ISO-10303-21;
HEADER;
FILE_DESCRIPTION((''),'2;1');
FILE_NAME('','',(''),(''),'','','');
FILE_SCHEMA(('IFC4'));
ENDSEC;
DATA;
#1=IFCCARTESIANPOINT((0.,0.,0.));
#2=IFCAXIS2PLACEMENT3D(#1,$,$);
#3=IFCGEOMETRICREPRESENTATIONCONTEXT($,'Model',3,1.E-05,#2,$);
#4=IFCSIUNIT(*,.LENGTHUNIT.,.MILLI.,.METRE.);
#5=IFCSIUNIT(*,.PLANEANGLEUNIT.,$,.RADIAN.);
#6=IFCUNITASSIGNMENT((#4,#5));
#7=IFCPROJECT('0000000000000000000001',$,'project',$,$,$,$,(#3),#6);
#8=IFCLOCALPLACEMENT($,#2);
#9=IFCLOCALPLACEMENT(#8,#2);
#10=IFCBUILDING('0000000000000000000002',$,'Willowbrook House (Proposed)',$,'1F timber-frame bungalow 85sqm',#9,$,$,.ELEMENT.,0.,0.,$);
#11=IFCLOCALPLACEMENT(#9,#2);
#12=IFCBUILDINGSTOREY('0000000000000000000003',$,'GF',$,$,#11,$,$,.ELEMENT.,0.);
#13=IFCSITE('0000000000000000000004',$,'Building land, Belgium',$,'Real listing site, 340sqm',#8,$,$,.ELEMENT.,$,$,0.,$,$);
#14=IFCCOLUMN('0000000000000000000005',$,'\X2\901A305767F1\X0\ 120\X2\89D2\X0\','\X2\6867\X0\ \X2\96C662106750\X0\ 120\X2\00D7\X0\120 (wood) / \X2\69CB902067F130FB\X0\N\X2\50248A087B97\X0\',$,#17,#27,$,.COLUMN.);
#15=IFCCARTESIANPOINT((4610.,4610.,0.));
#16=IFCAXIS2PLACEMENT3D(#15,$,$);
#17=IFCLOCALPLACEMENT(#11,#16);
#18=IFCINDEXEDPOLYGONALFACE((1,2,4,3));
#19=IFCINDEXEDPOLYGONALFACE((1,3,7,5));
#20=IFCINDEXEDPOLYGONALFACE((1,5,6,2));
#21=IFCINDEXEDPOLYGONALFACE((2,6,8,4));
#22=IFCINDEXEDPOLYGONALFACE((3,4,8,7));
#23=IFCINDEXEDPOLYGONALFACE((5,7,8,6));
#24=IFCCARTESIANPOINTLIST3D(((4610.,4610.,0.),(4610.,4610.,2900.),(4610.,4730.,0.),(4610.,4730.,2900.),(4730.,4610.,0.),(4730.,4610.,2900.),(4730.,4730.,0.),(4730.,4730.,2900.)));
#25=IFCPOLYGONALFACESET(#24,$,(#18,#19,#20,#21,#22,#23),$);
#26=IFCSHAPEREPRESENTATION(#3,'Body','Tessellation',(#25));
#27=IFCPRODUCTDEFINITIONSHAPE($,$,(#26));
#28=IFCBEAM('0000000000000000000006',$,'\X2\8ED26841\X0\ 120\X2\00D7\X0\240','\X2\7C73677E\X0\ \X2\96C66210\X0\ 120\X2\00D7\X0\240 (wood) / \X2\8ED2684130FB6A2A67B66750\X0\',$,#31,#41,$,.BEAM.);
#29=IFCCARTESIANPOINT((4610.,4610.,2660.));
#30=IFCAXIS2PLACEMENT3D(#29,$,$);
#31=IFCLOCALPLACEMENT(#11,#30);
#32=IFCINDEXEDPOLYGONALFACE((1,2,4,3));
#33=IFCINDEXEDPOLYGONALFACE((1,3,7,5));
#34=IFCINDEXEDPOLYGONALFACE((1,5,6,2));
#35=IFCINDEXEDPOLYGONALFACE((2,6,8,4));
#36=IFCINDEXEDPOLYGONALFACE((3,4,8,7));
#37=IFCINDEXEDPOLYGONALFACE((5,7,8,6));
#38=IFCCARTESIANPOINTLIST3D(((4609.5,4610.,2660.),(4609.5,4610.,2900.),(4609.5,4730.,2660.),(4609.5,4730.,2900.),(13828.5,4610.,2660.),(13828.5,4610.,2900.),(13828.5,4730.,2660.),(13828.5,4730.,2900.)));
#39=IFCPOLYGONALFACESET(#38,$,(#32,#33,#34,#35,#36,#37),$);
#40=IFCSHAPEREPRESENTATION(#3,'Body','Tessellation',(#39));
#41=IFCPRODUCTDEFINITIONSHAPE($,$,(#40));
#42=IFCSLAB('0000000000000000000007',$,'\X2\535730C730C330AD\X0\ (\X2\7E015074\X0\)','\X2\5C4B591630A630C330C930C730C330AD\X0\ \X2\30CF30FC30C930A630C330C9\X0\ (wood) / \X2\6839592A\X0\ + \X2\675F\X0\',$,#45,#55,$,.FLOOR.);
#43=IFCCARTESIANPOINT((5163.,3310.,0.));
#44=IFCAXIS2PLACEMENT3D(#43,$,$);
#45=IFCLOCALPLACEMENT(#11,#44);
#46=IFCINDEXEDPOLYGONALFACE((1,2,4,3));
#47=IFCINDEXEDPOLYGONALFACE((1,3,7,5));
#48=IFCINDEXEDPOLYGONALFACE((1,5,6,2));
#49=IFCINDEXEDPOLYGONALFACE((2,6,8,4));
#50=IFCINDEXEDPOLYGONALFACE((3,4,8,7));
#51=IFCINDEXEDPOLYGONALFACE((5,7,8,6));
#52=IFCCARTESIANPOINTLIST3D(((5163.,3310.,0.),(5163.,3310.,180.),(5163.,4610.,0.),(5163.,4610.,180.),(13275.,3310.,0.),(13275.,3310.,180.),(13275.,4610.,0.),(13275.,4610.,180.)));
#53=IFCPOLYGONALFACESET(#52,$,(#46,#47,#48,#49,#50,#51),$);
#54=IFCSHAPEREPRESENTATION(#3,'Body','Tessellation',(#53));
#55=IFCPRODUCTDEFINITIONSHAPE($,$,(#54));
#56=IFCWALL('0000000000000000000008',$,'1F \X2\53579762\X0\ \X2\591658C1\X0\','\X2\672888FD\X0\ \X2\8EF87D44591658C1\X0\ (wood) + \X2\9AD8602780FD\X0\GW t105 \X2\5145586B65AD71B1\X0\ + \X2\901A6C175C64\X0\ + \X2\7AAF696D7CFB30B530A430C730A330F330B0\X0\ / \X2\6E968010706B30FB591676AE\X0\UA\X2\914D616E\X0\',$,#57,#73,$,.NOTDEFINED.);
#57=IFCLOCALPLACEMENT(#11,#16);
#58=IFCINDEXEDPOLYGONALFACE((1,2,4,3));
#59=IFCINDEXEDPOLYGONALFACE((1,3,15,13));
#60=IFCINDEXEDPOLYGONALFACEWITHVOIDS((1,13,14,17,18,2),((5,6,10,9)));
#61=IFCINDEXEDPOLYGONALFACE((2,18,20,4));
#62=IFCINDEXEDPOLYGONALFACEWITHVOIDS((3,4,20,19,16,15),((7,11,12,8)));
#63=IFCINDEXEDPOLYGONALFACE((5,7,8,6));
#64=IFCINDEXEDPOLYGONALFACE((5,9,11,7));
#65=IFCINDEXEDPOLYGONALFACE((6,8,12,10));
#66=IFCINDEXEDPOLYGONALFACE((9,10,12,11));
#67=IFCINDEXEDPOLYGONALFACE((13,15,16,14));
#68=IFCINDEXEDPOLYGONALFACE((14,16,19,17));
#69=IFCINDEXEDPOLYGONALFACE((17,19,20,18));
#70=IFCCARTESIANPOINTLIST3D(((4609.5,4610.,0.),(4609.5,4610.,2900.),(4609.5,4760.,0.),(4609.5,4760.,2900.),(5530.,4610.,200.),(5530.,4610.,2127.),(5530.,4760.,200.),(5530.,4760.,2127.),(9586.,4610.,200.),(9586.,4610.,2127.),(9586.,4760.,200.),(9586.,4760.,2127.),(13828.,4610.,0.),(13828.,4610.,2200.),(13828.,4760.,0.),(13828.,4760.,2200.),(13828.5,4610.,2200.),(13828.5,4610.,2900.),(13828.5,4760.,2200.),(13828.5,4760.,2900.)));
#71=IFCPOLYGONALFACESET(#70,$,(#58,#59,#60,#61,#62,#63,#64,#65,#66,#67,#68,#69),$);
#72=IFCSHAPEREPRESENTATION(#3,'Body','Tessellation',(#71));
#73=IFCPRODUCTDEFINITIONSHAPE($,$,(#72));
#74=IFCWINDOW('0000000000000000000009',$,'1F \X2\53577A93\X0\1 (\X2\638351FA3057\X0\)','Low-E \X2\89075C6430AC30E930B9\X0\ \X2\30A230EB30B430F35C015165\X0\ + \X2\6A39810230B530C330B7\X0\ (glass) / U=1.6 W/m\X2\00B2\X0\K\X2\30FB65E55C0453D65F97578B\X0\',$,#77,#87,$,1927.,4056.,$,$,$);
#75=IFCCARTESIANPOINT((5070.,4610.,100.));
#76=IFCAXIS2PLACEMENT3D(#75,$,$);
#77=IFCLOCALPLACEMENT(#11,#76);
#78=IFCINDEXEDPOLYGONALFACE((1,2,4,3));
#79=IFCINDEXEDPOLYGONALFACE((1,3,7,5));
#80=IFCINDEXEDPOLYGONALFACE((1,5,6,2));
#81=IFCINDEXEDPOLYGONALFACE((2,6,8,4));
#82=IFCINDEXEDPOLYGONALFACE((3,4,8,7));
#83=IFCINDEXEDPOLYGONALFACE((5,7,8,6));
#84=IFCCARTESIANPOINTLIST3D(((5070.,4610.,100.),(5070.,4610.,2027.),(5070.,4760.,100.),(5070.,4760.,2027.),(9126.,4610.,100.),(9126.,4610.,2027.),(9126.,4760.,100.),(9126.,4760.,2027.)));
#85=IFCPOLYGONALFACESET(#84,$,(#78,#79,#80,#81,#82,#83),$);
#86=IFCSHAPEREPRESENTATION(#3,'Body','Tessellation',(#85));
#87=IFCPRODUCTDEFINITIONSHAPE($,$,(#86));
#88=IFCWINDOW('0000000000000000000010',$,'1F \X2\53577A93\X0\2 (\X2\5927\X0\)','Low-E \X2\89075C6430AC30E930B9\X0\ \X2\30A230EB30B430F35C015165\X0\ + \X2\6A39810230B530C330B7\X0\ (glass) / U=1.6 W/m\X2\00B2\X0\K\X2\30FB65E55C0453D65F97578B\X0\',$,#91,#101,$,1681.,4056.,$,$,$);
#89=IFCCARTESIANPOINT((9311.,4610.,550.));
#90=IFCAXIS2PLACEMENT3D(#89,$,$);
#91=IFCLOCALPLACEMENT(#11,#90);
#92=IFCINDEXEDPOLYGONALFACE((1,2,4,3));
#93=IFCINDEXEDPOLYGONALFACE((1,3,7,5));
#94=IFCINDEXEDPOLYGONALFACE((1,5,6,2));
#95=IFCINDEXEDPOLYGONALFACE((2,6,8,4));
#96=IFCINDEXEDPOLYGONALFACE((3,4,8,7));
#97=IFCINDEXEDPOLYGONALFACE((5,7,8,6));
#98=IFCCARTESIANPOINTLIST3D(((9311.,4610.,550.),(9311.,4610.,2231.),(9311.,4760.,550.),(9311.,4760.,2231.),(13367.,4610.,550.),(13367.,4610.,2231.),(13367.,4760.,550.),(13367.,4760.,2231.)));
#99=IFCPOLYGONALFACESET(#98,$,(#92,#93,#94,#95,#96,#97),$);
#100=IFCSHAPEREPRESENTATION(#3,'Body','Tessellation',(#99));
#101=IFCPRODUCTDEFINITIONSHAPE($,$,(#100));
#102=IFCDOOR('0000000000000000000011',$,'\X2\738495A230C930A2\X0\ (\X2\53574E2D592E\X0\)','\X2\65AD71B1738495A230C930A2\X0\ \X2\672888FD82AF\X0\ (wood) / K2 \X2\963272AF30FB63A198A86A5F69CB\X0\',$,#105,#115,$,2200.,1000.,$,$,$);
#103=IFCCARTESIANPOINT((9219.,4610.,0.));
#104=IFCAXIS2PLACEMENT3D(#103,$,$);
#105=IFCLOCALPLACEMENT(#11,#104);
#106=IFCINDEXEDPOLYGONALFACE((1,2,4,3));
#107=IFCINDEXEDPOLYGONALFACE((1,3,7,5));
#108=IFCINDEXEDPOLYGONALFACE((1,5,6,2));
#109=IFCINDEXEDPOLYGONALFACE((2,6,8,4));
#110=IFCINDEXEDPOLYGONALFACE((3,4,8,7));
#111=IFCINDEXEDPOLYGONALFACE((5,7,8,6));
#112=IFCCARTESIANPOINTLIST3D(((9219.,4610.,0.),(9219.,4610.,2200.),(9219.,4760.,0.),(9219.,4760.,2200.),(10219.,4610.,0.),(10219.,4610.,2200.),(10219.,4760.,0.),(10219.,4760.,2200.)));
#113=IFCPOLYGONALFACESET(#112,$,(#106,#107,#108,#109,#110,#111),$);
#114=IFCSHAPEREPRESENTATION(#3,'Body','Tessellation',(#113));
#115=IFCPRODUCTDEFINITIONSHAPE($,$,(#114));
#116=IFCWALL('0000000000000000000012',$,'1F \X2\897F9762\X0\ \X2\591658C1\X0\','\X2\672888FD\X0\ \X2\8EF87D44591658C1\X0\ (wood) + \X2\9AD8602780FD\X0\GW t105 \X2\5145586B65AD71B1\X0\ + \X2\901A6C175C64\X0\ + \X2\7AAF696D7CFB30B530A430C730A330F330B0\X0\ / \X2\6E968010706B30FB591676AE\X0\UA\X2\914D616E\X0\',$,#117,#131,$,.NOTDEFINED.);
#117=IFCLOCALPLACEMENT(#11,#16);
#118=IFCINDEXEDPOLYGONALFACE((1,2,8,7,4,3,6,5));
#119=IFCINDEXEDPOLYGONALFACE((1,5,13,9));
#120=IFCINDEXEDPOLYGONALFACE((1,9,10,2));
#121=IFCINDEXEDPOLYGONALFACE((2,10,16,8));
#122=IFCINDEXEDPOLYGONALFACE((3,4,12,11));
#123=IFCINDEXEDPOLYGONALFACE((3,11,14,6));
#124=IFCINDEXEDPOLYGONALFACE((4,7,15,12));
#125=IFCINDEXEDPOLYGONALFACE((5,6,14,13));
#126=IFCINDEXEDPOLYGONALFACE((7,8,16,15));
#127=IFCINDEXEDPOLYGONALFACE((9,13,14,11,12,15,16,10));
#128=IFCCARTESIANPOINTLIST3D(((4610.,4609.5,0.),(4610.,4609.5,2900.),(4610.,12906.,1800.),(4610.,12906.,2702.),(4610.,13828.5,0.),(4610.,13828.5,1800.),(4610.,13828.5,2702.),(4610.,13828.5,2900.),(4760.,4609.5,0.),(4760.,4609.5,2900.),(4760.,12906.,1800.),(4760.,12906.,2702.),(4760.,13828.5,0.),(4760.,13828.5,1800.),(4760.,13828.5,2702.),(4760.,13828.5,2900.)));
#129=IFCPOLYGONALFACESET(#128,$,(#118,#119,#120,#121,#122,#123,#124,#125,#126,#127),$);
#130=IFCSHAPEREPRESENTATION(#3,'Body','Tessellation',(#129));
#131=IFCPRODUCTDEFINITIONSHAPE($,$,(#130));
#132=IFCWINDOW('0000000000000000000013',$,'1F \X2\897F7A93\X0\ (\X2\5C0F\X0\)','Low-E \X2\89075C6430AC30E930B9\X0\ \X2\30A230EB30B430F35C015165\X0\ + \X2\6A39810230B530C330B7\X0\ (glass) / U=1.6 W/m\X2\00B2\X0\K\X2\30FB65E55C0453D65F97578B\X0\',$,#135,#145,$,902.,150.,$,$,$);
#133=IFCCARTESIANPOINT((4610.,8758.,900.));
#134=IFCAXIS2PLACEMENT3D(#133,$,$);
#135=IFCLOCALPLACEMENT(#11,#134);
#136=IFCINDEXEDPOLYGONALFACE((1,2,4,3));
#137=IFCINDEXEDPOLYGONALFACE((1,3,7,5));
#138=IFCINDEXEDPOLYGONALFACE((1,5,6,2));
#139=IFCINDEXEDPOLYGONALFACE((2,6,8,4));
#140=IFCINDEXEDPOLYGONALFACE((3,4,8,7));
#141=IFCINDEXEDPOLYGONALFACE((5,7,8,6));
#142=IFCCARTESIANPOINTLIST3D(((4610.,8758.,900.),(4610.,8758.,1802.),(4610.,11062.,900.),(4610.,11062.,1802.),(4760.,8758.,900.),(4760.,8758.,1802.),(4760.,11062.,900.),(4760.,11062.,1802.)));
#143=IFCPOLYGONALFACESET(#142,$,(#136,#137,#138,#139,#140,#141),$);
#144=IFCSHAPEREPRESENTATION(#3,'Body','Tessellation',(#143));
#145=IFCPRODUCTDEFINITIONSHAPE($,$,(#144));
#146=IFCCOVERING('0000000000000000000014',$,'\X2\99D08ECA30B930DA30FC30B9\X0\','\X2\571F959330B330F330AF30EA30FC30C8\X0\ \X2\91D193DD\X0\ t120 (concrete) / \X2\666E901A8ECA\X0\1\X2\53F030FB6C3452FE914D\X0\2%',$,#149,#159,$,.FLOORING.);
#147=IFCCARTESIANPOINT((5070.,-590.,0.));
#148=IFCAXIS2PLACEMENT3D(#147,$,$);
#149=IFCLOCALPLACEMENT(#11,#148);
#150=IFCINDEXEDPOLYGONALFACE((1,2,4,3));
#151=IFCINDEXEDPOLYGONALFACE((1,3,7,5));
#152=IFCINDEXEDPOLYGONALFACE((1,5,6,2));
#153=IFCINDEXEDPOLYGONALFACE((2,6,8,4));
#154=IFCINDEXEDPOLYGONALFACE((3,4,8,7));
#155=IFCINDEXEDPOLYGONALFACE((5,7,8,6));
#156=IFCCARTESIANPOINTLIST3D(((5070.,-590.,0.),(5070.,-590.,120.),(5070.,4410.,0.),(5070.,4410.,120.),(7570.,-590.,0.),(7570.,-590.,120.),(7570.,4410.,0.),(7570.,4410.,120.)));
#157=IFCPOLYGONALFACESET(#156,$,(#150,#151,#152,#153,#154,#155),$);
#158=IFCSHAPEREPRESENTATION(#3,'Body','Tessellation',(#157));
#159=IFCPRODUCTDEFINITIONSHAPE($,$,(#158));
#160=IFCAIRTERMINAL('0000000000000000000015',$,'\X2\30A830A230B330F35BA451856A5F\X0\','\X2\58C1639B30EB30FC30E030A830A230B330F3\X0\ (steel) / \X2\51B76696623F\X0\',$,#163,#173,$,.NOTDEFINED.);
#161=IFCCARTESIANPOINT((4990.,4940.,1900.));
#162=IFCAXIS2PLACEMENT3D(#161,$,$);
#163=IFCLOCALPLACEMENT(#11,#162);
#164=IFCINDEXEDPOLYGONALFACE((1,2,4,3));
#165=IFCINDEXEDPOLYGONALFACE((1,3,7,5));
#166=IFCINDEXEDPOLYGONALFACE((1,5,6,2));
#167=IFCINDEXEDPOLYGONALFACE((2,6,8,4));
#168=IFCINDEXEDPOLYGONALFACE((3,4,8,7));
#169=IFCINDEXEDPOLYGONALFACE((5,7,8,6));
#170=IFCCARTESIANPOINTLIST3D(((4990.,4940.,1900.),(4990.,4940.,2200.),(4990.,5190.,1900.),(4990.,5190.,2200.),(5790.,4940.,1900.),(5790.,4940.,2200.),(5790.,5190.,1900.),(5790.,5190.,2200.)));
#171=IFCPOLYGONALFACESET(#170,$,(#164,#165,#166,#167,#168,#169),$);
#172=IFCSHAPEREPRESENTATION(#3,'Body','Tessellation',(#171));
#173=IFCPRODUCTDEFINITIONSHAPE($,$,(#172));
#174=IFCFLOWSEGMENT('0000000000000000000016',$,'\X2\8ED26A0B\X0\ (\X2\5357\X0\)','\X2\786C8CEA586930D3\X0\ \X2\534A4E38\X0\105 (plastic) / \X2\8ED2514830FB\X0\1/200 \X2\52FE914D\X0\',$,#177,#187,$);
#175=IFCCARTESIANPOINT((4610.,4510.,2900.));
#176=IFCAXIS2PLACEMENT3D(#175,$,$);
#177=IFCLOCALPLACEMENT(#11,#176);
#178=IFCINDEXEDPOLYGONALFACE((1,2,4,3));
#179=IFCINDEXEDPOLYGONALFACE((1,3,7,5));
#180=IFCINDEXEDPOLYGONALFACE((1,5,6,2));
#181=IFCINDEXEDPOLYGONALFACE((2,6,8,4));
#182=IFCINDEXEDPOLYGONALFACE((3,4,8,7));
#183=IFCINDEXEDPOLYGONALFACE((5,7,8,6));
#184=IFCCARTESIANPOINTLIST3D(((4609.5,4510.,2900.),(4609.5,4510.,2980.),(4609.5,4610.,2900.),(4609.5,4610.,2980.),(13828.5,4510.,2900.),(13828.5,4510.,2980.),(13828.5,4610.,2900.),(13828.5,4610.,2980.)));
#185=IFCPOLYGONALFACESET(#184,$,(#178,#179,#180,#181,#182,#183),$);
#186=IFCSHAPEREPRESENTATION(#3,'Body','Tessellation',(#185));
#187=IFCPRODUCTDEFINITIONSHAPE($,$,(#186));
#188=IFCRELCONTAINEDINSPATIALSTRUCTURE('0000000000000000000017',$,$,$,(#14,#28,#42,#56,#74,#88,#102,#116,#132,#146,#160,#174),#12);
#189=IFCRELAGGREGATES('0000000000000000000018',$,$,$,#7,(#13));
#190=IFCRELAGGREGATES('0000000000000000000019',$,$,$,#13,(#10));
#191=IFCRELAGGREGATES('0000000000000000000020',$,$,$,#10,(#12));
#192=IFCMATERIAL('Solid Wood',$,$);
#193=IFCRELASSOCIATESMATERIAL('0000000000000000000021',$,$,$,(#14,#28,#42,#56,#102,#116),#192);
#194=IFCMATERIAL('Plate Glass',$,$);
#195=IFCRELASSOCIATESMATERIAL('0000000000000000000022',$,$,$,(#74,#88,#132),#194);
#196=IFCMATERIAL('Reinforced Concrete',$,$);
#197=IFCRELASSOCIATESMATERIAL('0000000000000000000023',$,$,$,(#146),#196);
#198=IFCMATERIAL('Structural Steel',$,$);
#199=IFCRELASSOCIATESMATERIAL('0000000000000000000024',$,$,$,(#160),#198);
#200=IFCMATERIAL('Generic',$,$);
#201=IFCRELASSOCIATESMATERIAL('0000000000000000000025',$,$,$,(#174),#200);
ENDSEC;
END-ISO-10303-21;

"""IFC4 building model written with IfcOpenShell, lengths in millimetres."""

from ifc_helpers import new_model, si_unit, frame, frame_2d, origin, place, context, project, spatial, rectangle, extrude, material, element, fill, save


model = new_model("IFC4")

# Units and contexts
model_context = context("Model", 3, precision=1e-05, world=origin())
ifc_project = project(units=[si_unit("LENGTHUNIT", "METRE", prefix="MILLI"), si_unit("PLANEANGLEUNIT", "RADIAN")], contexts=[model_context])

# Site, building, storey
site_placement = place(None, origin())
site = spatial("IfcSite", under=ifc_project, at=site_placement, Name="Building land, Belgium", ObjectType="Real listing site, 340sqm", CompositionType="ELEMENT", RefElevation=0.0)
building_placement = place(site_placement, origin())
building = spatial("IfcBuilding", under=site, at=building_placement, Name="Willowbrook House (Proposed)", ObjectType="1F timber-frame bungalow 85sqm", CompositionType="ELEMENT", ElevationOfRefHeight=0.0, ElevationOfTerrain=0.0)
storey_placement = place(building_placement, origin())
storey = spatial("IfcBuildingStorey", under=building, at=storey_placement, Name="GF", CompositionType="ELEMENT", Elevation=0.0)

# Column
ifc_material_1 = material(Name="Solid Wood")
column_1_placement = place(storey_placement, frame((4610.0, 4610.0, 0.0)))
element("IfcColumn", 1, at=column_1_placement, inside=storey, material=ifc_material_1, Name="通し柱 120角", Description="桧 集成材 120×120 (wood) / 構造柱・N値計算", PredefinedType="COLUMN", context=model_context, shape_type="SweptSolid", body=[
    extrude(rectangle(XDim=120.0, YDim=120.0, at=frame_2d((60.0, 60.0))), frame((4610.0, 4610.0, 0.0)), (0.0, 0.0, 1.0), 2900.0),
])

# Beam
beam_1_placement = place(storey_placement, frame((4610.0, 4610.0, 2660.0)))
element("IfcBeam", 2, at=beam_1_placement, inside=storey, material=ifc_material_1, Name="軒桁 120×240", Description="米松 集成 120×240 (wood) / 軒桁・横架材", PredefinedType="BEAM", context=model_context, shape_type="SweptSolid", body=[
    extrude(rectangle(XDim=9219.0, YDim=120.0, at=frame_2d((4609.0, 60.0))), frame((4610.0, 4610.0, 2660.0)), (0.0, 0.0, 1.0), 240.0),
])

# Slab
ifc_material_2 = material(Name="Reinforced Concrete")
slab_1_placement = place(storey_placement, frame((5163.0, 3310.0, 0.0)))
element("IfcSlab", 3, at=slab_1_placement, inside=storey, material=ifc_material_1, Name="南デッキ (縁側)", Description="屋外ウッドデッキ ハードウッド (wood) / 根太 + 束", PredefinedType="FLOOR", context=model_context, shape_type="SweptSolid", body=[
    extrude(rectangle(XDim=8112.0, YDim=1300.0, at=frame_2d((4056.0, 650.0))), frame((5163.0, 3310.0, 0.0)), (0.0, 0.0, 1.0), 180.0),
])

# Wall, openings, windows, door
wall_1_placement = place(storey_placement, frame((4610.0, 4610.0, 0.0)))
wall_1 = element("IfcWall", 4, at=wall_1_placement, inside=storey, material=ifc_material_1, Name="1F 南面 外壁", Description="木製 軸組外壁 (wood) + 高性能GW t105 充填断熱 + 通気層 + 窯業系サイディング / 準耐火・外皮UA配慮", PredefinedType="NOTDEFINED", context=model_context, shape_type="SweptSolid", body=[
    extrude(rectangle(XDim=9219.0, YDim=150.0, at=frame_2d((4609.0, 75.0))), frame((4610.0, 4610.0, 0.0)), (0.0, 0.0, 1.0), 2900.0),
])
opening_1_placement = place(storey_placement, frame((5070.0, 4610.0, 100.0)))
opening_1 = element("IfcOpeningElement", 5, at=opening_1_placement, cuts=wall_1, PredefinedType="NOTDEFINED", context=model_context, shape_type="SweptSolid", body=[
    extrude(rectangle(XDim=4056.0, YDim=150.0, at=frame_2d((2028.0, 75.0))), frame((5070.0, 4610.0, 100.0)), (0.0, 0.0, 1.0), 1927.0),
])
opening_2_placement = place(storey_placement, frame((9311.0, 4610.0, 550.0)))
opening_2 = element("IfcOpeningElement", 6, at=opening_2_placement, cuts=wall_1, PredefinedType="NOTDEFINED", context=model_context, shape_type="SweptSolid", body=[
    extrude(rectangle(XDim=4056.0, YDim=150.0, at=frame_2d((2028.0, 75.0))), frame((9311.0, 4610.0, 550.0)), (0.0, 0.0, 1.0), 1681.0),
])
opening_3_placement = place(storey_placement, frame((9219.0, 4610.0, 0.0)))
opening_3 = element("IfcOpeningElement", 7, at=opening_3_placement, cuts=wall_1, PredefinedType="NOTDEFINED", context=model_context, shape_type="SweptSolid", body=[
    extrude(rectangle(XDim=1000.0, YDim=150.0, at=frame_2d((500.0, 75.0))), frame((9219.0, 4610.0, 0.0)), (0.0, 0.0, 1.0), 2200.0),
])
ifc_material_3 = material(Name="Plate Glass")
window_1_placement = place(storey_placement, frame((5070.0, 4610.0, 100.0)))
window_1 = element("IfcWindow", 8, at=window_1_placement, inside=storey, material=ifc_material_3, Name="1F 南窓1 (掃出し)", Description="Low-E 複層ガラス アルゴン封入 + 樹脂サッシ (glass) / U=1.6 W/m²K・日射取得型", OverallHeight=1927.0, OverallWidth=4056.0, context=model_context, shape_type="SweptSolid", body=[
    extrude(rectangle(XDim=4056.0, YDim=150.0, at=frame_2d((2028.0, 75.0))), frame((5070.0, 4610.0, 100.0)), (0.0, 0.0, 1.0), 1927.0),
])
fill(opening_1, window_1)
window_2_placement = place(storey_placement, frame((9311.0, 4610.0, 550.0)))
window_2 = element("IfcWindow", 9, at=window_2_placement, inside=storey, material=ifc_material_3, Name="1F 南窓2 (大)", Description="Low-E 複層ガラス アルゴン封入 + 樹脂サッシ (glass) / U=1.6 W/m²K・日射取得型", OverallHeight=1681.0, OverallWidth=4056.0, context=model_context, shape_type="SweptSolid", body=[
    extrude(rectangle(XDim=4056.0, YDim=150.0, at=frame_2d((2028.0, 75.0))), frame((9311.0, 4610.0, 550.0)), (0.0, 0.0, 1.0), 1681.0),
])
fill(opening_2, window_2)
door_placement = place(storey_placement, frame((9219.0, 4610.0, 0.0)))
door = element("IfcDoor", 10, at=door_placement, inside=storey, material=ifc_material_1, Name="玄関ドア (南中央)", Description="断熱玄関ドア 木製芯 (wood) / K2 防犯・採風機構", OverallHeight=2200.0, OverallWidth=1000.0, context=model_context, shape_type="SweptSolid", body=[
    extrude(rectangle(XDim=1000.0, YDim=150.0, at=frame_2d((500.0, 75.0))), frame((9219.0, 4610.0, 0.0)), (0.0, 0.0, 1.0), 2200.0),
])
fill(opening_3, door)

# Wall, opening, window
wall_2_placement = place(storey_placement, frame((4610.0, 4610.0, 0.0)))
wall_2 = element("IfcWall", 11, at=wall_2_placement, inside=storey, material=ifc_material_1, Name="1F 西面 外壁", Description="木製 軸組外壁 (wood) + 高性能GW t105 充填断熱 + 通気層 + 窯業系サイディング / 準耐火・外皮UA配慮", PredefinedType="NOTDEFINED", context=model_context, shape_type="SweptSolid", body=[
    extrude(rectangle(XDim=150.0, YDim=9219.0, at=frame_2d((75.0, 4609.0))), frame((4610.0, 4610.0, 0.0)), (0.0, 0.0, 1.0), 2900.0),
])
opening_4_placement = place(storey_placement, frame((4610.0, 8758.0, 900.0)))
opening_4 = element("IfcOpeningElement", 12, at=opening_4_placement, cuts=wall_2, PredefinedType="NOTDEFINED", context=model_context, shape_type="SweptSolid", body=[
    extrude(rectangle(XDim=150.0, YDim=2304.0, at=frame_2d((75.0, 1152.0))), frame((4610.0, 8758.0, 900.0)), (0.0, 0.0, 1.0), 902.0),
])
window_3_placement = place(storey_placement, frame((4610.0, 8758.0, 900.0)))
window_3 = element("IfcWindow", 13, at=window_3_placement, inside=storey, material=ifc_material_3, Name="1F 西窓 (小)", Description="Low-E 複層ガラス アルゴン封入 + 樹脂サッシ (glass) / U=1.6 W/m²K・日射取得型", OverallHeight=902.0, OverallWidth=150.0, context=model_context, shape_type="SweptSolid", body=[
    extrude(rectangle(XDim=150.0, YDim=2304.0, at=frame_2d((75.0, 1152.0))), frame((4610.0, 8758.0, 900.0)), (0.0, 0.0, 1.0), 902.0),
])
fill(opening_4, window_3)

# Shared definitions
ifc_material_4 = material(Name="Structural Steel")

# Covering
ifc_material_5 = material(Name="Generic")
covering_1_placement = place(storey_placement, frame((5070.0, -590.0, 0.0)))
element("IfcCovering", 14, at=covering_1_placement, inside=storey, material=ifc_material_2, Name="駐車スペース", Description="土間コンクリート 金鏝 t120 (concrete) / 普通車1台・水勾配2%", PredefinedType="FLOORING", context=model_context, shape_type="SweptSolid", body=[
    extrude(rectangle(XDim=2500.0, YDim=5000.0, at=frame_2d((1250.0, 2500.0))), frame((5070.0, -590.0, 0.0)), (0.0, 0.0, 1.0), 120.0),
])

# Air terminal
air_terminal_placement = place(storey_placement, frame((4990.0, 4940.0, 1900.0)))
element("IfcAirTerminal", 15, at=air_terminal_placement, inside=storey, material=ifc_material_4, Name="エアコン室内機", Description="壁掛ルームエアコン (steel) / 冷暖房", PredefinedType="NOTDEFINED", context=model_context, shape_type="SweptSolid", body=[
    extrude(rectangle(XDim=800.0, YDim=250.0, at=frame_2d((400.0, 125.0))), frame((4990.0, 4940.0, 1900.0)), (0.0, 0.0, 1.0), 300.0),
])

# Flow segment
flow_segment_1_placement = place(storey_placement, frame((4610.0, 4510.0, 2900.0)))
element("IfcFlowSegment", 16, at=flow_segment_1_placement, inside=storey, material=ifc_material_5, Name="軒樋 (南)", Description="硬質塩ビ 半丸105 (plastic) / 軒先・1/200 勾配", context=model_context, shape_type="SweptSolid", body=[
    extrude(rectangle(XDim=9219.0, YDim=100.0, at=frame_2d((4609.0, 50.0))), frame((4610.0, 4510.0, 2900.0)), (0.0, 0.0, 1.0), 80.0),
])

save(model, "model.ifc")
